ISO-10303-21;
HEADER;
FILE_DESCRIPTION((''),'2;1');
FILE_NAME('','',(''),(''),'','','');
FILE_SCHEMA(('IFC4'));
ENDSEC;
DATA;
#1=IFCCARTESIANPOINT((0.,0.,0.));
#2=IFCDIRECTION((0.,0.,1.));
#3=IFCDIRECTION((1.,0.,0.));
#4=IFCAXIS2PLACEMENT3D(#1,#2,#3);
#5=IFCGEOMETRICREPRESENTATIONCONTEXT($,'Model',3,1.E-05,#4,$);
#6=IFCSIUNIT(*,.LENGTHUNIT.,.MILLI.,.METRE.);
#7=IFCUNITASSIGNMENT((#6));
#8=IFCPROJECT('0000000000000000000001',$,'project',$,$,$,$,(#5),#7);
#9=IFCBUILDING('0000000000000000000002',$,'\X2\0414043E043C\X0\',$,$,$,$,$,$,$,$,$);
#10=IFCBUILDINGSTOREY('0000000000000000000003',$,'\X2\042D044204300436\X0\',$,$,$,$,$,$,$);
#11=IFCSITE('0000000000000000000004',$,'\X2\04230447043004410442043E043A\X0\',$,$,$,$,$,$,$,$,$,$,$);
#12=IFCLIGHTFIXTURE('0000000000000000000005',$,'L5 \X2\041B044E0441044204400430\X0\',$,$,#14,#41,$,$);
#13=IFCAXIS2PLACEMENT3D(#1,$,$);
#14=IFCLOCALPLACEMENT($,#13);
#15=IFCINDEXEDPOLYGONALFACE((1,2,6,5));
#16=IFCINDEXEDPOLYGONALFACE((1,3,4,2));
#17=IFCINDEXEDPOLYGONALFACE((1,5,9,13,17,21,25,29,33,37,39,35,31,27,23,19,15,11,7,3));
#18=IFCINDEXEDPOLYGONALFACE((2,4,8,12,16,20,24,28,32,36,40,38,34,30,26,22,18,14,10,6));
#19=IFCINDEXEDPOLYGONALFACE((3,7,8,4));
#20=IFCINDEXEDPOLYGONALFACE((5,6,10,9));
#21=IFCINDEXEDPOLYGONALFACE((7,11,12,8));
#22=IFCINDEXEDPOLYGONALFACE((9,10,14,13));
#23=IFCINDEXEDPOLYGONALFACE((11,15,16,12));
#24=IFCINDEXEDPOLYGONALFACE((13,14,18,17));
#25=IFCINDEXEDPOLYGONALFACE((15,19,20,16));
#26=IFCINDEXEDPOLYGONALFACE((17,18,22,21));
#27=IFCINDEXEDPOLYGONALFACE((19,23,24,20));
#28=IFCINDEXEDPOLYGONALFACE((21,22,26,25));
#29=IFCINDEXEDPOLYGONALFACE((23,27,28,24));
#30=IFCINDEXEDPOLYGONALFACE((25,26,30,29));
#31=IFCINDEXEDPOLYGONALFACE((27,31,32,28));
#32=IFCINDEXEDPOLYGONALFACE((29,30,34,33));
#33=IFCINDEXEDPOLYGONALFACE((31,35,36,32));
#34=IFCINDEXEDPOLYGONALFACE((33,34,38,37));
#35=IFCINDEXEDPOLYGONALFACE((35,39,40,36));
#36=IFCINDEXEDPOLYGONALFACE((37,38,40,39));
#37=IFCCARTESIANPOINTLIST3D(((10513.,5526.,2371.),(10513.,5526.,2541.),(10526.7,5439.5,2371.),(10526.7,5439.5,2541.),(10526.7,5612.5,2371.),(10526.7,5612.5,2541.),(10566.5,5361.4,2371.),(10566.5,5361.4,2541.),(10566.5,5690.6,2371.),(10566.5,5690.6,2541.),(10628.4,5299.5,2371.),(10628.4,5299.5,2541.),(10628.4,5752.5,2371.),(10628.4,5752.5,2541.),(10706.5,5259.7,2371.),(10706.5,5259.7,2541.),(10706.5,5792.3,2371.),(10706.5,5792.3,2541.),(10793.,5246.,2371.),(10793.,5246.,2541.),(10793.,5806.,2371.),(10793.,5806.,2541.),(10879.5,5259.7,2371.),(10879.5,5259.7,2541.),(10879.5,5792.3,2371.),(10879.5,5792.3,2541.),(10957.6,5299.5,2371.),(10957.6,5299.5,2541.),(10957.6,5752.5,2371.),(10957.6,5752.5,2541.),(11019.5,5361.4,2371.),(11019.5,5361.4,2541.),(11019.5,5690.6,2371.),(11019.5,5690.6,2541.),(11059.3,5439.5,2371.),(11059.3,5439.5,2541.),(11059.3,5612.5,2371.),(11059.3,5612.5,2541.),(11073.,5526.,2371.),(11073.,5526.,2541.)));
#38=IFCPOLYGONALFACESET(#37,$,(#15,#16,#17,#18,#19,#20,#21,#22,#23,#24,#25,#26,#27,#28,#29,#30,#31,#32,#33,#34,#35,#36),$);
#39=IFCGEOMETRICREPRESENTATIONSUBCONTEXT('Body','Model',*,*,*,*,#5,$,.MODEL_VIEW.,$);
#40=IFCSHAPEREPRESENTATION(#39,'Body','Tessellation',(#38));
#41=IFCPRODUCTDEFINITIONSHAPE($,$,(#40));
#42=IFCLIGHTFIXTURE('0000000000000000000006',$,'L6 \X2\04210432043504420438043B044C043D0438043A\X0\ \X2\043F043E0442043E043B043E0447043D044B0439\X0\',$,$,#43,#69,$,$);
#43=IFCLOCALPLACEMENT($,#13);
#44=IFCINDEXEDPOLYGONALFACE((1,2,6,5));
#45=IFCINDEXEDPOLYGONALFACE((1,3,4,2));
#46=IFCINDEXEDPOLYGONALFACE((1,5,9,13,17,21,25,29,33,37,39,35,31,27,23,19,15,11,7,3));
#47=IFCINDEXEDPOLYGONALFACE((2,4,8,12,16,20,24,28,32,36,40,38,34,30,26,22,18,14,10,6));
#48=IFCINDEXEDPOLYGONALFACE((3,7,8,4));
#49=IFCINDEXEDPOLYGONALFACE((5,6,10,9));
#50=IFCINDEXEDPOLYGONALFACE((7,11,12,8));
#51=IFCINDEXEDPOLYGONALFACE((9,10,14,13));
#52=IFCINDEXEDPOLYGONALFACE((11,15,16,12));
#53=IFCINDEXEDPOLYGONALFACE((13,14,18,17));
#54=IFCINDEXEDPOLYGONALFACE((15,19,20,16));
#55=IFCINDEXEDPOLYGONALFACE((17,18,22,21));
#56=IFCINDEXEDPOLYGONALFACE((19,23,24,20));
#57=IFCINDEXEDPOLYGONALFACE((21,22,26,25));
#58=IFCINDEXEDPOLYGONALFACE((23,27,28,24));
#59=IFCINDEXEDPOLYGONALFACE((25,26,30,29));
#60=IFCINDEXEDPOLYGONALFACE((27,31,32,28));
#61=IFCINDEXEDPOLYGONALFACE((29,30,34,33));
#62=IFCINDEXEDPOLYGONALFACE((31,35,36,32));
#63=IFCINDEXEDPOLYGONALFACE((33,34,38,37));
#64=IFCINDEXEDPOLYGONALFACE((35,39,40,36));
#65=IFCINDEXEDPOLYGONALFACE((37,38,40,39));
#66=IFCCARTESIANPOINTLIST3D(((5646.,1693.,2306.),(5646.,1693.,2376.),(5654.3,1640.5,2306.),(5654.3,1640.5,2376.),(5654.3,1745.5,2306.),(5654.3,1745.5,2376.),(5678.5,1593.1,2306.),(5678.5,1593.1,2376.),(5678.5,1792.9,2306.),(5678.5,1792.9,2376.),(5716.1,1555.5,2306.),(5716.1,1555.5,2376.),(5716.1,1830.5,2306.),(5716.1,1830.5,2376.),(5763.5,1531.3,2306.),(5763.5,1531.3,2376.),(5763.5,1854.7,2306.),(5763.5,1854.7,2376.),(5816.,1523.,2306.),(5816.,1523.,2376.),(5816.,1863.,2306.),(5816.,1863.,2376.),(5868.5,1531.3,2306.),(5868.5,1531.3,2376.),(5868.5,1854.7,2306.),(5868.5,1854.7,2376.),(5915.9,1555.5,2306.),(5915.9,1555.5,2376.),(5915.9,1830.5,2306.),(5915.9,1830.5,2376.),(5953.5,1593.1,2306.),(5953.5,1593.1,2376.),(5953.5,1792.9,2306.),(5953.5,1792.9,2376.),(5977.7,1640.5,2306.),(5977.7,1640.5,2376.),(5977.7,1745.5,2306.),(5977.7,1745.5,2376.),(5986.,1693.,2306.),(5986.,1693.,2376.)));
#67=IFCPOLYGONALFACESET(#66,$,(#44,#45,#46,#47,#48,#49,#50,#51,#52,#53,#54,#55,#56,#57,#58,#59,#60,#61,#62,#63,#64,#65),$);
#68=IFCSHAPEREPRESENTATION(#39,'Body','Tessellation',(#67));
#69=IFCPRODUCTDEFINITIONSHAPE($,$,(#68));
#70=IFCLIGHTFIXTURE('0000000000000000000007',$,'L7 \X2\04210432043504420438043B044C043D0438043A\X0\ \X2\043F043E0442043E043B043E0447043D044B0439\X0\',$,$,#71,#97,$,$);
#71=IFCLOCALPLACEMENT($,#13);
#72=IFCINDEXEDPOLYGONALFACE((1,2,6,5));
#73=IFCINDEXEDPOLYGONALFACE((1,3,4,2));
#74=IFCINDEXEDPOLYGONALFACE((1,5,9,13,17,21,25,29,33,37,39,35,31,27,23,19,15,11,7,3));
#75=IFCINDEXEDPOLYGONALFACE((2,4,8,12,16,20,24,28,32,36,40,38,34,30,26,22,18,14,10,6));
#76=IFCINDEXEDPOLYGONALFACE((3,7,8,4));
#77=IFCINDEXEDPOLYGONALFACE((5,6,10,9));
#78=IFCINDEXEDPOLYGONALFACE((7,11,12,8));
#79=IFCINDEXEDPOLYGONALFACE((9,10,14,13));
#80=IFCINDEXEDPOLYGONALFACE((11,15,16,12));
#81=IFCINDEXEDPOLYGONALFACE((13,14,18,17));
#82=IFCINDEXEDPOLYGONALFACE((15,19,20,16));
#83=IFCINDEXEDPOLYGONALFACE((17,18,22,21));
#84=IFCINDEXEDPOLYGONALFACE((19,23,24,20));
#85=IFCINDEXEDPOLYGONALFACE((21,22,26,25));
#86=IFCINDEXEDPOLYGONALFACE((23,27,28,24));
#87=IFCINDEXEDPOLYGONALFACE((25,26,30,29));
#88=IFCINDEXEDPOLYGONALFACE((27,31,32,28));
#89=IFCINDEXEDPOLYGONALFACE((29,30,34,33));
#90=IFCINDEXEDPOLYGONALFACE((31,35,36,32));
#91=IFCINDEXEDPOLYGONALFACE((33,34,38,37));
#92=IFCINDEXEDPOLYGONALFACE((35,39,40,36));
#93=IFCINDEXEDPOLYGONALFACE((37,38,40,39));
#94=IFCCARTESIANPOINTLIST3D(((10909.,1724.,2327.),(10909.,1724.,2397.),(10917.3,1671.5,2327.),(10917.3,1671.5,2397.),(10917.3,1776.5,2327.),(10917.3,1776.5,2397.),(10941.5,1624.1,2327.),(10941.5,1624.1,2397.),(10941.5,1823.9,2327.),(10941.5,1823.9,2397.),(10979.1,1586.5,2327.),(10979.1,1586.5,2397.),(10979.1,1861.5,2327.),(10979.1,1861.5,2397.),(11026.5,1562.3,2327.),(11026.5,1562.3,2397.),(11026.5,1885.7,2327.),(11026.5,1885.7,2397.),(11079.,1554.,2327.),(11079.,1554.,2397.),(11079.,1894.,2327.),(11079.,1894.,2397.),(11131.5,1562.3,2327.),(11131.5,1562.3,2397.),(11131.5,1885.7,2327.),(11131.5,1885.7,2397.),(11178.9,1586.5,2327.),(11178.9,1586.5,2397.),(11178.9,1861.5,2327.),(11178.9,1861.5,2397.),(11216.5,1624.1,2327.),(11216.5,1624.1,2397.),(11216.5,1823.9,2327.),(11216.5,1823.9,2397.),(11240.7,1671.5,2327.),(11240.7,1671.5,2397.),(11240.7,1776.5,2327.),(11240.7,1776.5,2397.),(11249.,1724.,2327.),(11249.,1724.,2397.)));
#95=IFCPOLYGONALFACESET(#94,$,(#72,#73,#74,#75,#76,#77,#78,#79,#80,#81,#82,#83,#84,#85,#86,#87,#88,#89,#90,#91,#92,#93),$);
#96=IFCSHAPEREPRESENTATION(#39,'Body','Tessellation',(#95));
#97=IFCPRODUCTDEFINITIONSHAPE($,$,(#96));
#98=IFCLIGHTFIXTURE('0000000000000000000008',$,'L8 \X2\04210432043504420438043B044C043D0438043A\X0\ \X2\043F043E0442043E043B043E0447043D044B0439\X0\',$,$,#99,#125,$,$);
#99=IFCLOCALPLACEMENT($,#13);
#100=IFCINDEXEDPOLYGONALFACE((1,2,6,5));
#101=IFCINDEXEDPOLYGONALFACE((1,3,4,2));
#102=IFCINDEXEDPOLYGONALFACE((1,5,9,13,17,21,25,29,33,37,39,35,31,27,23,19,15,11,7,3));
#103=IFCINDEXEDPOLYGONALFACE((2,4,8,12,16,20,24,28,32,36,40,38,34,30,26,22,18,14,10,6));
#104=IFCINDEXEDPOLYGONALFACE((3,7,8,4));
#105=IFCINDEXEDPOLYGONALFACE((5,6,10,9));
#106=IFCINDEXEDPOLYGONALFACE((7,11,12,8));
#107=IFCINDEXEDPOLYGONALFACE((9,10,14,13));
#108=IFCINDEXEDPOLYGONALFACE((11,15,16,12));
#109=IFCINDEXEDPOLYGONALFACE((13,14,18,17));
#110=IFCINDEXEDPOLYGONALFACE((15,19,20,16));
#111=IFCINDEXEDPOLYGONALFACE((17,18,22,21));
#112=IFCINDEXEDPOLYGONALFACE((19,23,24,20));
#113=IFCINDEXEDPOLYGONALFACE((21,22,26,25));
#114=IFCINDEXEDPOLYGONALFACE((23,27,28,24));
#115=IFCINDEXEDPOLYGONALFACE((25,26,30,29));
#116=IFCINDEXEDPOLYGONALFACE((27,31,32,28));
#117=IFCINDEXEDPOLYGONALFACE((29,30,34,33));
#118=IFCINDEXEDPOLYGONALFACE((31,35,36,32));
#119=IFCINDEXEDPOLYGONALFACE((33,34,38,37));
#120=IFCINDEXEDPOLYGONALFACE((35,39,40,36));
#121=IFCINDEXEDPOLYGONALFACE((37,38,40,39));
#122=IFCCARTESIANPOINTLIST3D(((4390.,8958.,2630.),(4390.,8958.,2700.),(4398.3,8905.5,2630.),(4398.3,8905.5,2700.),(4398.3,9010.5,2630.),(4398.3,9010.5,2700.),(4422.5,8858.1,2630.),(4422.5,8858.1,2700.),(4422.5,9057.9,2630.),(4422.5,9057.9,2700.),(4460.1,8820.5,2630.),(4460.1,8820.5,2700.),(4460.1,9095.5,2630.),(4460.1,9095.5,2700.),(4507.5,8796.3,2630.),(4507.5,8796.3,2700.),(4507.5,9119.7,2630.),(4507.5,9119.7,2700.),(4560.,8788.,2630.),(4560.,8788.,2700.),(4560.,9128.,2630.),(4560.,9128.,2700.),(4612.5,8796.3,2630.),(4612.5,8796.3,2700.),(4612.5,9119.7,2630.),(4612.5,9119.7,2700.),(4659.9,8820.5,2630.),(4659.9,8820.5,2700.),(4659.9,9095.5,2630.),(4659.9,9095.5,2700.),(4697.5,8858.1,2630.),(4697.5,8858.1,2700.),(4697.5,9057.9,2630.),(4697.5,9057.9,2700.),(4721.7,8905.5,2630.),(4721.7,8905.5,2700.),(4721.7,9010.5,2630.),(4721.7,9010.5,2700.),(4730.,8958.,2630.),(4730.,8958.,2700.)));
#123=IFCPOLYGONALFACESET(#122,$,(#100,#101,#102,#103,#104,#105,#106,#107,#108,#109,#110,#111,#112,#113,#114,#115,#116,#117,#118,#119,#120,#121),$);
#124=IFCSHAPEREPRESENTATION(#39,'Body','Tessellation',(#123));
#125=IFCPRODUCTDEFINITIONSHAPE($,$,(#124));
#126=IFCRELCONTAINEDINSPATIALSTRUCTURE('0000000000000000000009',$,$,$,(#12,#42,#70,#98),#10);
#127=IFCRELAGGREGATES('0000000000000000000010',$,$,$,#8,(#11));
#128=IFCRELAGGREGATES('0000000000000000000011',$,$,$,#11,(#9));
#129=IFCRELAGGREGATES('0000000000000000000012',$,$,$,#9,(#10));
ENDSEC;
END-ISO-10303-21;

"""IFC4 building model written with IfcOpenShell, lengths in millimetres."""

from ifc_helpers import new_model, si_unit, frame, origin, origin_with_axes, place, context, subcontext, project, spatial, polyline, outline, extrude, element, save


model = new_model("IFC4")

# Units and contexts
model_context = context("Model", 3, precision=1e-05, world=origin_with_axes())
body_context = subcontext(model_context, "Body", "Model", "MODEL_VIEW")
ifc_project = project(units=[si_unit("LENGTHUNIT", "METRE", prefix="MILLI")], contexts=[model_context])

# Site, building, storey
site = spatial("IfcSite", under=ifc_project, Name="Участок")
building = spatial("IfcBuilding", under=site, Name="Дом")
storey = spatial("IfcBuildingStorey", under=building, Name="Этаж")

# Light fixtures
light_fixture_1_placement = place(None, frame((0.0, 0.0, 2371.0), z_axis=(0.0, 0.0, 1.0), x_axis=(1.0, 0.0, 0.0)))
element("IfcLightFixture", 1, at=light_fixture_1_placement, inside=storey, Name="L5 Люстра", context=body_context, shape_type="SweptSolid", body=[
    extrude(outline(polyline([(11073.0, 5526.0), (11059.3, 5612.5), (11019.5, 5690.6), (10957.6, 5752.5), (10879.5, 5792.3), (10793.0, 5806.0), (10706.5, 5792.3), (10628.4, 5752.5), (10566.5, 5690.6), (10526.7, 5612.5), (10513.0, 5526.0), (10526.7, 5439.5), (10566.5, 5361.4), (10628.4, 5299.5), (10706.5, 5259.7), (10793.0, 5246.0), (10879.5, 5259.7), (10957.6, 5299.5), (11019.5, 5361.4), (11059.3, 5439.5), (11073.0, 5526.0)])), origin(), (0.0, 0.0, 1.0), 170.0),
])
light_fixture_2_placement = place(None, frame((0.0, 0.0, 2306.0), z_axis=(0.0, 0.0, 1.0), x_axis=(1.0, 0.0, 0.0)))
element("IfcLightFixture", 2, at=light_fixture_2_placement, inside=storey, Name="L6 Светильник потолочный", context=body_context, shape_type="SweptSolid", body=[
    extrude(outline(polyline([(5986.0, 1693.0), (5977.7, 1745.5), (5953.5, 1792.9), (5915.9, 1830.5), (5868.5, 1854.7), (5816.0, 1863.0), (5763.5, 1854.7), (5716.1, 1830.5), (5678.5, 1792.9), (5654.3, 1745.5), (5646.0, 1693.0), (5654.3, 1640.5), (5678.5, 1593.1), (5716.1, 1555.5), (5763.5, 1531.3), (5816.0, 1523.0), (5868.5, 1531.3), (5915.9, 1555.5), (5953.5, 1593.1), (5977.7, 1640.5), (5986.0, 1693.0)])), origin(), (0.0, 0.0, 1.0), 70.0),
])
light_fixture_3_placement = place(None, frame((0.0, 0.0, 2327.0), z_axis=(0.0, 0.0, 1.0), x_axis=(1.0, 0.0, 0.0)))
element("IfcLightFixture", 3, at=light_fixture_3_placement, inside=storey, Name="L7 Светильник потолочный", context=body_context, shape_type="SweptSolid", body=[
    extrude(outline(polyline([(11249.0, 1724.0), (11240.7, 1776.5), (11216.5, 1823.9), (11178.9, 1861.5), (11131.5, 1885.7), (11079.0, 1894.0), (11026.5, 1885.7), (10979.1, 1861.5), (10941.5, 1823.9), (10917.3, 1776.5), (10909.0, 1724.0), (10917.3, 1671.5), (10941.5, 1624.1), (10979.1, 1586.5), (11026.5, 1562.3), (11079.0, 1554.0), (11131.5, 1562.3), (11178.9, 1586.5), (11216.5, 1624.1), (11240.7, 1671.5), (11249.0, 1724.0)])), origin(), (0.0, 0.0, 1.0), 70.0),
])
light_fixture_4_placement = place(None, frame((0.0, 0.0, 2630.0), z_axis=(0.0, 0.0, 1.0), x_axis=(1.0, 0.0, 0.0)))
element("IfcLightFixture", 4, at=light_fixture_4_placement, inside=storey, Name="L8 Светильник потолочный", context=body_context, shape_type="SweptSolid", body=[
    extrude(outline(polyline([(4730.0, 8958.0), (4721.7, 9010.5), (4697.5, 9057.9), (4659.9, 9095.5), (4612.5, 9119.7), (4560.0, 9128.0), (4507.5, 9119.7), (4460.1, 9095.5), (4422.5, 9057.9), (4398.3, 9010.5), (4390.0, 8958.0), (4398.3, 8905.5), (4422.5, 8858.1), (4460.1, 8820.5), (4507.5, 8796.3), (4560.0, 8788.0), (4612.5, 8796.3), (4659.9, 8820.5), (4697.5, 8858.1), (4721.7, 8905.5), (4730.0, 8958.0)])), origin(), (0.0, 0.0, 1.0), 70.0),
])

save(model, "model.ifc")
